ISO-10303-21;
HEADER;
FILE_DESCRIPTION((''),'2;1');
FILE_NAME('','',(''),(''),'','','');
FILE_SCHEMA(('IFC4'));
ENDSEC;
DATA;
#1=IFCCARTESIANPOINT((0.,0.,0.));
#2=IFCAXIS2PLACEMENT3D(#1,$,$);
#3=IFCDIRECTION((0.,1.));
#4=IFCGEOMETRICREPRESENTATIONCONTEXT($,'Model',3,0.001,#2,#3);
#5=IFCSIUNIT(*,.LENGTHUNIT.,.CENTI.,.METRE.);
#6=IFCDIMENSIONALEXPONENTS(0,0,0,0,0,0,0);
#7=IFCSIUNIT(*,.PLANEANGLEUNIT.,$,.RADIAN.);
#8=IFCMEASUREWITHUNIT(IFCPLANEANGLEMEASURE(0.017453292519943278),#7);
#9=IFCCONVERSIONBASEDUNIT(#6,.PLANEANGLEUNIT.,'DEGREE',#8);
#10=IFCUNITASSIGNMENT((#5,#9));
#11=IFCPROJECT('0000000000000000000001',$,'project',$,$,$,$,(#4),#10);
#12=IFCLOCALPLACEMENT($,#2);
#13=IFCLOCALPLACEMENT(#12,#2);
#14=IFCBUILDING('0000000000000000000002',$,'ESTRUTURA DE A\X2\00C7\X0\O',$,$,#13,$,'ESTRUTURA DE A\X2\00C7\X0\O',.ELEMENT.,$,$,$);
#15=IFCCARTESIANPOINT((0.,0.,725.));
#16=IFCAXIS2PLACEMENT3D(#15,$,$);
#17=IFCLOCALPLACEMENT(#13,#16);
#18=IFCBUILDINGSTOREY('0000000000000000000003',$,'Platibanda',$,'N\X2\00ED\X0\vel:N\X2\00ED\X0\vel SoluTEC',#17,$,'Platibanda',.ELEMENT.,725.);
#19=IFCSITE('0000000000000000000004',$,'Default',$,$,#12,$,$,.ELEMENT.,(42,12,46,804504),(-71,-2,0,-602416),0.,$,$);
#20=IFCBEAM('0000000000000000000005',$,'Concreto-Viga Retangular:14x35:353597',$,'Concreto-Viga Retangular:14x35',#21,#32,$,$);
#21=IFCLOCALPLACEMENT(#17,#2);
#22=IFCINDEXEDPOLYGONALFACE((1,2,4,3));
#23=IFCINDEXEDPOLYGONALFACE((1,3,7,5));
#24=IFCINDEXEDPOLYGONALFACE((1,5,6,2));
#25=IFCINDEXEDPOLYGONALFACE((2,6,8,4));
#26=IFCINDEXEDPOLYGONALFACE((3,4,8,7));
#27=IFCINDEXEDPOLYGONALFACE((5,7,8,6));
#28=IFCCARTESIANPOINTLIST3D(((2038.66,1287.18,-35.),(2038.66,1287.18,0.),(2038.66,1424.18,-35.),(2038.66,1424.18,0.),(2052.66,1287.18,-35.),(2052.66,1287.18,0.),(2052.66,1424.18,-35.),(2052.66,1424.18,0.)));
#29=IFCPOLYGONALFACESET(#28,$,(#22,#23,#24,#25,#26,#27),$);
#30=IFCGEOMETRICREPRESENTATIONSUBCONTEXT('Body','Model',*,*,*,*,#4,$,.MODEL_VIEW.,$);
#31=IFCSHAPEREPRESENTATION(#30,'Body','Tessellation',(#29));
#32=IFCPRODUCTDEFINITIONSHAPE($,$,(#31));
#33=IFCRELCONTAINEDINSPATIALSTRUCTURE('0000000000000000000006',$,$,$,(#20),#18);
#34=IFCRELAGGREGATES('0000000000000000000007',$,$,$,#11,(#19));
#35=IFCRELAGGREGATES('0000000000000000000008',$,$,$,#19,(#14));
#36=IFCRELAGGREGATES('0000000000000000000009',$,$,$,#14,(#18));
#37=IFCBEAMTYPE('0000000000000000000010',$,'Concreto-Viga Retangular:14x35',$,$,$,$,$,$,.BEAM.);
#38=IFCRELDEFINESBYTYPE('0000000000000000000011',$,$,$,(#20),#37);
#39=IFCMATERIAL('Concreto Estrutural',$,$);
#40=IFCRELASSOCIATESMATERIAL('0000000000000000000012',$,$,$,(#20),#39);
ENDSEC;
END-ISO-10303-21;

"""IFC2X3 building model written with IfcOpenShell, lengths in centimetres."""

from ifc_helpers import new_model, entity, si_unit, converted_unit, direction, frame, frame_2d, origin, place, context, subcontext, project, spatial, rectangle, extrude, material, type_object, element, save


model = new_model("IFC2X3")

# Units and contexts
model_context = context("Model", 3, precision=0.001, world=origin(), true_north=direction((0.0, 1.0)))
body_context = subcontext(model_context, "Body", "Model", "MODEL_VIEW")
ifc_project = project(units=[si_unit("LENGTHUNIT", "METRE", prefix="CENTI"), converted_unit("PLANEANGLEUNIT", "DEGREE", entity("IfcPlaneAngleMeasure", 0.017453292519943278), si_unit("PLANEANGLEUNIT", "RADIAN"), dimensions=[0, 0, 0, 0, 0, 0, 0])], contexts=[model_context])

# Site, building, storey
site_placement = place(None, origin())
site = spatial("IfcSite", under=ifc_project, at=site_placement, Name="Default", CompositionType="ELEMENT", RefLatitude=(42, 12, 46, 804504), RefLongitude=(-71, -2, 0, -602416), RefElevation=0.0)
building_placement = place(site_placement, origin())
building = spatial("IfcBuilding", under=site, at=building_placement, Name="ESTRUTURA DE AÇO", LongName="ESTRUTURA DE AÇO", CompositionType="ELEMENT")
storey_placement = place(building_placement, frame((0.0, 0.0, 725.0)))
storey = spatial("IfcBuildingStorey", under=building, at=storey_placement, Name="Platibanda", ObjectType="Nível:Nível SoluTEC", LongName="Platibanda", CompositionType="ELEMENT", Elevation=725.0)

# Beam
ifc_material = material(Name="Concreto Estrutural")
beam_type = type_object("IfcBeamType", Name="Concreto-Viga Retangular:14x35", PredefinedType="BEAM")
beam_placement = place(storey_placement, frame((2045.66, 1287.18, 0.0), z_axis=(0.0, 0.0, 1.0), x_axis=(0.0, 1.0, 0.0)))
element("IfcBeam", 1, at=beam_placement, inside=storey, type_object=beam_type, material=ifc_material, Name="Concreto-Viga Retangular:14x35:353597", ObjectType="Concreto-Viga Retangular:14x35", context=body_context, shape_type="SweptSolid", body=[
    extrude(rectangle(XDim=35.0, YDim=14.0, at=frame_2d((0.0, 0.0), x_axis=(1.0, 0.0))), frame((0.0, 0.0, -17.5), z_axis=(1.0, 0.0, 0.0), x_axis=(0.0, 0.0, -1.0)), (0.0, 0.0, 1.0), 137.0),
])

save(model, "model.ifc")
